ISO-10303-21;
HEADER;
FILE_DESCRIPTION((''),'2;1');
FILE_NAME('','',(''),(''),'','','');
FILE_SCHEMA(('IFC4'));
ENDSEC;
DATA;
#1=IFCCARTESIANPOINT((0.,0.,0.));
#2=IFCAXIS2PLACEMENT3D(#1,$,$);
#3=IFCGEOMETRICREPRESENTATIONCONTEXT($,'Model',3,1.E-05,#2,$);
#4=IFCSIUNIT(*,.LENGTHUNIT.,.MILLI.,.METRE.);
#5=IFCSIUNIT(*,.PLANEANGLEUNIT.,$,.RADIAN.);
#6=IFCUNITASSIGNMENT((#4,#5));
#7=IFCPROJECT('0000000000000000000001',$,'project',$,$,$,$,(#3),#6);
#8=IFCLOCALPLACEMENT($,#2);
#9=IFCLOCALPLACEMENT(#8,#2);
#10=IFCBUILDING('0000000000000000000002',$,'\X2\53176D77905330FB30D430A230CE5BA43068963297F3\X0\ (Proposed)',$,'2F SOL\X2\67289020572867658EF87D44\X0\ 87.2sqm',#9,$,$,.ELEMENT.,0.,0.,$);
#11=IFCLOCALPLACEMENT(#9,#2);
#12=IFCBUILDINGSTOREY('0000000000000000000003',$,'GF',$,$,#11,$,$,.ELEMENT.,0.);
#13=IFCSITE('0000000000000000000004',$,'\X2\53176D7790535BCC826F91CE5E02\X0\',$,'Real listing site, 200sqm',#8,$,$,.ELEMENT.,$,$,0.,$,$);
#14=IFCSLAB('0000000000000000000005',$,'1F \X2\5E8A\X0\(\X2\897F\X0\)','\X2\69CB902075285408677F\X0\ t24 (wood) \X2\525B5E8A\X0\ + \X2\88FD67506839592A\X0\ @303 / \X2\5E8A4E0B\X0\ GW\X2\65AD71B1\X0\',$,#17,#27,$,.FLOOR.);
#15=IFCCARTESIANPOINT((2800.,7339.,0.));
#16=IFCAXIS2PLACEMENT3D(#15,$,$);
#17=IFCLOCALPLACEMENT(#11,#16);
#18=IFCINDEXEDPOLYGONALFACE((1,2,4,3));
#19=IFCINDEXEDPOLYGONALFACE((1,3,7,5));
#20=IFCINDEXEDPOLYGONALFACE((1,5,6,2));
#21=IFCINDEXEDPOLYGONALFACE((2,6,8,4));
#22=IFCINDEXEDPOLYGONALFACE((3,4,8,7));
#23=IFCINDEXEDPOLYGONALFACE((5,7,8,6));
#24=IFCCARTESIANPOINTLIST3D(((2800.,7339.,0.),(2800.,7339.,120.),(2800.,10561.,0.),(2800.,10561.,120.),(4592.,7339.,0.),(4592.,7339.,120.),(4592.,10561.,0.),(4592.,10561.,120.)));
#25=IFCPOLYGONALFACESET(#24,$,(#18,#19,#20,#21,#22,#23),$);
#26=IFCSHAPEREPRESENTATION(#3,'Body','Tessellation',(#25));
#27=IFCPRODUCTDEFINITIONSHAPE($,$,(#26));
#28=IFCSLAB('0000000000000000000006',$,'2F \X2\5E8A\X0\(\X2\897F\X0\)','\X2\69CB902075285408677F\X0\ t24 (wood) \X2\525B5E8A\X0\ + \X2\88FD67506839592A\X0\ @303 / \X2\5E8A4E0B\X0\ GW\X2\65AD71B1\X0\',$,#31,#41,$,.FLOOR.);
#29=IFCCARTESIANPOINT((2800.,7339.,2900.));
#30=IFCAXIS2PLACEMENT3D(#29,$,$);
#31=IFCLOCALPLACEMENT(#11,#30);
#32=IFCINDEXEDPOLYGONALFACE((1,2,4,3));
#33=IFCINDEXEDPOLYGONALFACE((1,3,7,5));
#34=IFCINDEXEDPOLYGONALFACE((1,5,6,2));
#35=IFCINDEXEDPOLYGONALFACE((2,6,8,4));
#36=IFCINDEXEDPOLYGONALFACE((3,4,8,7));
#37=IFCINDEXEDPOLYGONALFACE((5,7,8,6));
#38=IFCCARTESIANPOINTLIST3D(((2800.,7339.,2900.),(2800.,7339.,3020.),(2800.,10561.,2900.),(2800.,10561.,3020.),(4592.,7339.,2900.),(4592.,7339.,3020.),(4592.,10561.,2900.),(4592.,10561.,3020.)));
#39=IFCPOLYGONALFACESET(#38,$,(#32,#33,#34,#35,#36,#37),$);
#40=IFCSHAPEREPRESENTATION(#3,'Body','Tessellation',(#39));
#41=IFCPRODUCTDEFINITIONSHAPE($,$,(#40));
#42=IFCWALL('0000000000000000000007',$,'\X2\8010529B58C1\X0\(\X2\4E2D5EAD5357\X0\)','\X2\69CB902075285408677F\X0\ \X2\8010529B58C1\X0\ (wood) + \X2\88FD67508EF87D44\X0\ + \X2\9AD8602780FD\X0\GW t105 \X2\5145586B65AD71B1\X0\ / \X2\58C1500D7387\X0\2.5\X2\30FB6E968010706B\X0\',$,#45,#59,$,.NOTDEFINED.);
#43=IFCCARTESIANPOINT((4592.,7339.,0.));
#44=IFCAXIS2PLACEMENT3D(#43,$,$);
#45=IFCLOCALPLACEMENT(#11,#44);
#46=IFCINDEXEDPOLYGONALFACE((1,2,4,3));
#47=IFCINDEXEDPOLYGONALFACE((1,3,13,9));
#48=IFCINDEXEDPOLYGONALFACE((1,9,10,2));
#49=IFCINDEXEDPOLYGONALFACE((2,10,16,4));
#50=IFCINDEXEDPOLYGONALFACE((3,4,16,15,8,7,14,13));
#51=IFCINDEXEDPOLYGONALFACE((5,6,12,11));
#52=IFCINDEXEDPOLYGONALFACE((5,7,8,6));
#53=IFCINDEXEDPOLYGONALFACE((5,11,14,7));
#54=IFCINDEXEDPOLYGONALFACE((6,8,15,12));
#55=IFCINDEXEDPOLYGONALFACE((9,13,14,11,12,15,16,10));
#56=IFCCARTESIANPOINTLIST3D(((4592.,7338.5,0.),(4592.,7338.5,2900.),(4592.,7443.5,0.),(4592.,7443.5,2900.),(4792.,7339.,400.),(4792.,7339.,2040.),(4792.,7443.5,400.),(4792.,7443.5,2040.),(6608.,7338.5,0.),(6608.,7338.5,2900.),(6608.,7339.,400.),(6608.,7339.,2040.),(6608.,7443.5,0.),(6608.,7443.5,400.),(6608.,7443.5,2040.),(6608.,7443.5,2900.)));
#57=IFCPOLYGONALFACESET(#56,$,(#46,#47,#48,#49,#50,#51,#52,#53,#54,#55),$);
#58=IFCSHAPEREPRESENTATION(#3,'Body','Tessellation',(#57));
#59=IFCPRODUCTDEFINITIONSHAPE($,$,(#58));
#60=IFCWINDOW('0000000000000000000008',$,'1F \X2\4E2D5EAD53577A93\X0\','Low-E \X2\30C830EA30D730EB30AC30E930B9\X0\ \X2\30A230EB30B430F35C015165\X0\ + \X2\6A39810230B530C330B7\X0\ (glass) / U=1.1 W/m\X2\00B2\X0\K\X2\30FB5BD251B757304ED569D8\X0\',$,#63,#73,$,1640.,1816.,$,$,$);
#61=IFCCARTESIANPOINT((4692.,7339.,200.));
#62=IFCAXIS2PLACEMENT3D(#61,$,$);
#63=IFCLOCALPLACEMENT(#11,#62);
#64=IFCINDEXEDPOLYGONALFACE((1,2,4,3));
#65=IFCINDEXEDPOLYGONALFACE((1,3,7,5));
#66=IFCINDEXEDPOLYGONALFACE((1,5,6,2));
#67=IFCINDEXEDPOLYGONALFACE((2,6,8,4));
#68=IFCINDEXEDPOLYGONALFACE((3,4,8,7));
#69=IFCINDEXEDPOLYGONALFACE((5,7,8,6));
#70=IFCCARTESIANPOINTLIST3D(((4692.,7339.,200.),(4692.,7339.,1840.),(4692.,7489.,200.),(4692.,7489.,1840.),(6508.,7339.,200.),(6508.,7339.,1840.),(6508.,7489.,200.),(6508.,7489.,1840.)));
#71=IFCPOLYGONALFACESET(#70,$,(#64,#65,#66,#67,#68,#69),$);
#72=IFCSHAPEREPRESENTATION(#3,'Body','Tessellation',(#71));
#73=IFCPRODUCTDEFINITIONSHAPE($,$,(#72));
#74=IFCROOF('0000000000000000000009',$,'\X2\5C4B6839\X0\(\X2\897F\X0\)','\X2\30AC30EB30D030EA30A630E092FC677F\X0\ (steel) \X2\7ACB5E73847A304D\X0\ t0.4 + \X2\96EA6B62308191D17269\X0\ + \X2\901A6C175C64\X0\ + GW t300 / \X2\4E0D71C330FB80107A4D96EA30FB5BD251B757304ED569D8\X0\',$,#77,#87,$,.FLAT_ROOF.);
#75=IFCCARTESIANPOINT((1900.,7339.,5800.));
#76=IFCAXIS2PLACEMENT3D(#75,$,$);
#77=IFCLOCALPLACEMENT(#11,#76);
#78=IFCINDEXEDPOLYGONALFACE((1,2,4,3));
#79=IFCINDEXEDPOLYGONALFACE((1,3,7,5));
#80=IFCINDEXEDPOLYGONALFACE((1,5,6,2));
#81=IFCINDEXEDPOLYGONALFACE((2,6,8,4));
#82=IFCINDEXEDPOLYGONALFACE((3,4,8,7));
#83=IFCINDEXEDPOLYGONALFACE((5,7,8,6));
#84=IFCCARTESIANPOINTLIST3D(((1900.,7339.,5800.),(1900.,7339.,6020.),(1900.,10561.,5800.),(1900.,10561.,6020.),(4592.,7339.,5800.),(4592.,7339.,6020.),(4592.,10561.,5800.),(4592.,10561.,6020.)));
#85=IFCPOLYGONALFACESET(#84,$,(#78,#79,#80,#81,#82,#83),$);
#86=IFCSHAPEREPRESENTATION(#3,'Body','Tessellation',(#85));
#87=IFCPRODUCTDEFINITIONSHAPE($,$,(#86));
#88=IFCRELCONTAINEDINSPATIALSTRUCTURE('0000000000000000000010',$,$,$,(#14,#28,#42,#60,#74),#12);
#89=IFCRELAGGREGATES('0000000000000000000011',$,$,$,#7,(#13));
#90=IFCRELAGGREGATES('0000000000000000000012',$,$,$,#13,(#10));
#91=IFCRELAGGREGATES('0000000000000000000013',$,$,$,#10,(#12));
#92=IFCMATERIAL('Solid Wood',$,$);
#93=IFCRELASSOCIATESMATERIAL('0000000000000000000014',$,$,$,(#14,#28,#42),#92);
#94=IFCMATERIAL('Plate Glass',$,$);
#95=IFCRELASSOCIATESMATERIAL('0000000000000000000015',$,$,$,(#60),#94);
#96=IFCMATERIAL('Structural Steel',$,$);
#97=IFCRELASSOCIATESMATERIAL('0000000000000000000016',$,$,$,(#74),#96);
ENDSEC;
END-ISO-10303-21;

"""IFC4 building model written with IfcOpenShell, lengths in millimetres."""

from ifc_helpers import new_model, si_unit, frame, frame_2d, origin, place, context, project, spatial, rectangle, extrude, material, element, fill, save


model = new_model("IFC4")

# Units and contexts
model_context = context("Model", 3, precision=1e-05, world=origin())
ifc_project = project(units=[si_unit("LENGTHUNIT", "METRE", prefix="MILLI"), si_unit("PLANEANGLEUNIT", "RADIAN")], contexts=[model_context])

# Site, building, storey
site_placement = place(None, origin())
site = spatial("IfcSite", under=ifc_project, at=site_placement, Name="北海道富良野市", ObjectType="Real listing site, 200sqm", CompositionType="ELEMENT", RefElevation=0.0)
building_placement = place(site_placement, origin())
building = spatial("IfcBuilding", under=site, at=building_placement, Name="北海道・ピアノ室と防音 (Proposed)", ObjectType="2F SOL木造在来軸組 87.2sqm", CompositionType="ELEMENT", ElevationOfRefHeight=0.0, ElevationOfTerrain=0.0)
storey_placement = place(building_placement, origin())
storey = spatial("IfcBuildingStorey", under=building, at=storey_placement, Name="GF", CompositionType="ELEMENT", Elevation=0.0)

# Shared definitions
ifc_material_1 = material(Name="Solid Wood")

# Slabs
slab_1_placement = place(storey_placement, frame((2800.0, 7339.0, 0.0)))
element("IfcSlab", 1, at=slab_1_placement, inside=storey, material=ifc_material_1, Name="1F 床(西)", Description="構造用合板 t24 (wood) 剛床 + 製材根太 @303 / 床下 GW断熱", PredefinedType="FLOOR", context=model_context, shape_type="SweptSolid", body=[
    extrude(rectangle(XDim=1792.0, YDim=3222.0, at=frame_2d((896.0, 1611.0))), frame((2800.0, 7339.0, 0.0)), (0.0, 0.0, 1.0), 120.0),
])
slab_2_placement = place(storey_placement, frame((2800.0, 7339.0, 2900.0)))
element("IfcSlab", 2, at=slab_2_placement, inside=storey, material=ifc_material_1, Name="2F 床(西)", Description="構造用合板 t24 (wood) 剛床 + 製材根太 @303 / 床下 GW断熱", PredefinedType="FLOOR", context=model_context, shape_type="SweptSolid", body=[
    extrude(rectangle(XDim=1792.0, YDim=3222.0, at=frame_2d((896.0, 1611.0))), frame((2800.0, 7339.0, 2900.0)), (0.0, 0.0, 1.0), 120.0),
])

# Wall, opening, window
wall_1_placement = place(storey_placement, frame((4592.0, 7339.0, 0.0)))
wall_1 = element("IfcWall", 3, at=wall_1_placement, inside=storey, material=ifc_material_1, Name="耐力壁(中庭南)", Description="構造用合板 耐力壁 (wood) + 製材軸組 + 高性能GW t105 充填断熱 / 壁倍率2.5・準耐火", PredefinedType="NOTDEFINED", context=model_context, shape_type="SweptSolid", body=[
    extrude(rectangle(XDim=2016.0, YDim=105.0, at=frame_2d((1008.0, 52.0))), frame((4592.0, 7339.0, 0.0)), (0.0, 0.0, 1.0), 2900.0),
])
opening_placement = place(storey_placement, frame((4692.0, 7339.0, 200.0)))
opening = element("IfcOpeningElement", 4, at=opening_placement, cuts=wall_1, PredefinedType="NOTDEFINED", context=model_context, shape_type="SweptSolid", body=[
    extrude(rectangle(XDim=1816.0, YDim=150.0, at=frame_2d((908.0, 75.0))), frame((4692.0, 7339.0, 200.0)), (0.0, 0.0, 1.0), 1640.0),
])
ifc_material_2 = material(Name="Plate Glass")
window_placement = place(storey_placement, frame((4692.0, 7339.0, 200.0)))
window = element("IfcWindow", 5, at=window_placement, inside=storey, material=ifc_material_2, Name="1F 中庭南窓", Description="Low-E トリプルガラス アルゴン封入 + 樹脂サッシ (glass) / U=1.1 W/m²K・寒冷地仕様", OverallHeight=1640.0, OverallWidth=1816.0, context=model_context, shape_type="SweptSolid", body=[
    extrude(rectangle(XDim=1816.0, YDim=150.0, at=frame_2d((908.0, 75.0))), frame((4692.0, 7339.0, 200.0)), (0.0, 0.0, 1.0), 1640.0),
])
fill(opening, window)

# Roof
ifc_material_3 = material(Name="Structural Steel")
for number, where, name in (
    (6, (1900.0, 7339.0, 5800.0), "屋根(西)"),
):
    element("IfcRoof", number, at=place(storey_placement, frame(where)), inside=storey, material=ifc_material_3, Name=name, Description="ガルバリウム鋼板 (steel) 立平葺き t0.4 + 雪止め金物 + 通気層 + GW t300 / 不燃・耐積雪・寒冷地仕様", PredefinedType="FLAT_ROOF", context=model_context, shape_type="SweptSolid", body=[
        extrude(rectangle(XDim=2692.0, YDim=3222.0, at=frame_2d((1346.0, 1611.0))), frame((1900.0, 7339.0, 5800.0)), (0.0, 0.0, 1.0), 220.0),
    ])

save(model, "model.ifc")
